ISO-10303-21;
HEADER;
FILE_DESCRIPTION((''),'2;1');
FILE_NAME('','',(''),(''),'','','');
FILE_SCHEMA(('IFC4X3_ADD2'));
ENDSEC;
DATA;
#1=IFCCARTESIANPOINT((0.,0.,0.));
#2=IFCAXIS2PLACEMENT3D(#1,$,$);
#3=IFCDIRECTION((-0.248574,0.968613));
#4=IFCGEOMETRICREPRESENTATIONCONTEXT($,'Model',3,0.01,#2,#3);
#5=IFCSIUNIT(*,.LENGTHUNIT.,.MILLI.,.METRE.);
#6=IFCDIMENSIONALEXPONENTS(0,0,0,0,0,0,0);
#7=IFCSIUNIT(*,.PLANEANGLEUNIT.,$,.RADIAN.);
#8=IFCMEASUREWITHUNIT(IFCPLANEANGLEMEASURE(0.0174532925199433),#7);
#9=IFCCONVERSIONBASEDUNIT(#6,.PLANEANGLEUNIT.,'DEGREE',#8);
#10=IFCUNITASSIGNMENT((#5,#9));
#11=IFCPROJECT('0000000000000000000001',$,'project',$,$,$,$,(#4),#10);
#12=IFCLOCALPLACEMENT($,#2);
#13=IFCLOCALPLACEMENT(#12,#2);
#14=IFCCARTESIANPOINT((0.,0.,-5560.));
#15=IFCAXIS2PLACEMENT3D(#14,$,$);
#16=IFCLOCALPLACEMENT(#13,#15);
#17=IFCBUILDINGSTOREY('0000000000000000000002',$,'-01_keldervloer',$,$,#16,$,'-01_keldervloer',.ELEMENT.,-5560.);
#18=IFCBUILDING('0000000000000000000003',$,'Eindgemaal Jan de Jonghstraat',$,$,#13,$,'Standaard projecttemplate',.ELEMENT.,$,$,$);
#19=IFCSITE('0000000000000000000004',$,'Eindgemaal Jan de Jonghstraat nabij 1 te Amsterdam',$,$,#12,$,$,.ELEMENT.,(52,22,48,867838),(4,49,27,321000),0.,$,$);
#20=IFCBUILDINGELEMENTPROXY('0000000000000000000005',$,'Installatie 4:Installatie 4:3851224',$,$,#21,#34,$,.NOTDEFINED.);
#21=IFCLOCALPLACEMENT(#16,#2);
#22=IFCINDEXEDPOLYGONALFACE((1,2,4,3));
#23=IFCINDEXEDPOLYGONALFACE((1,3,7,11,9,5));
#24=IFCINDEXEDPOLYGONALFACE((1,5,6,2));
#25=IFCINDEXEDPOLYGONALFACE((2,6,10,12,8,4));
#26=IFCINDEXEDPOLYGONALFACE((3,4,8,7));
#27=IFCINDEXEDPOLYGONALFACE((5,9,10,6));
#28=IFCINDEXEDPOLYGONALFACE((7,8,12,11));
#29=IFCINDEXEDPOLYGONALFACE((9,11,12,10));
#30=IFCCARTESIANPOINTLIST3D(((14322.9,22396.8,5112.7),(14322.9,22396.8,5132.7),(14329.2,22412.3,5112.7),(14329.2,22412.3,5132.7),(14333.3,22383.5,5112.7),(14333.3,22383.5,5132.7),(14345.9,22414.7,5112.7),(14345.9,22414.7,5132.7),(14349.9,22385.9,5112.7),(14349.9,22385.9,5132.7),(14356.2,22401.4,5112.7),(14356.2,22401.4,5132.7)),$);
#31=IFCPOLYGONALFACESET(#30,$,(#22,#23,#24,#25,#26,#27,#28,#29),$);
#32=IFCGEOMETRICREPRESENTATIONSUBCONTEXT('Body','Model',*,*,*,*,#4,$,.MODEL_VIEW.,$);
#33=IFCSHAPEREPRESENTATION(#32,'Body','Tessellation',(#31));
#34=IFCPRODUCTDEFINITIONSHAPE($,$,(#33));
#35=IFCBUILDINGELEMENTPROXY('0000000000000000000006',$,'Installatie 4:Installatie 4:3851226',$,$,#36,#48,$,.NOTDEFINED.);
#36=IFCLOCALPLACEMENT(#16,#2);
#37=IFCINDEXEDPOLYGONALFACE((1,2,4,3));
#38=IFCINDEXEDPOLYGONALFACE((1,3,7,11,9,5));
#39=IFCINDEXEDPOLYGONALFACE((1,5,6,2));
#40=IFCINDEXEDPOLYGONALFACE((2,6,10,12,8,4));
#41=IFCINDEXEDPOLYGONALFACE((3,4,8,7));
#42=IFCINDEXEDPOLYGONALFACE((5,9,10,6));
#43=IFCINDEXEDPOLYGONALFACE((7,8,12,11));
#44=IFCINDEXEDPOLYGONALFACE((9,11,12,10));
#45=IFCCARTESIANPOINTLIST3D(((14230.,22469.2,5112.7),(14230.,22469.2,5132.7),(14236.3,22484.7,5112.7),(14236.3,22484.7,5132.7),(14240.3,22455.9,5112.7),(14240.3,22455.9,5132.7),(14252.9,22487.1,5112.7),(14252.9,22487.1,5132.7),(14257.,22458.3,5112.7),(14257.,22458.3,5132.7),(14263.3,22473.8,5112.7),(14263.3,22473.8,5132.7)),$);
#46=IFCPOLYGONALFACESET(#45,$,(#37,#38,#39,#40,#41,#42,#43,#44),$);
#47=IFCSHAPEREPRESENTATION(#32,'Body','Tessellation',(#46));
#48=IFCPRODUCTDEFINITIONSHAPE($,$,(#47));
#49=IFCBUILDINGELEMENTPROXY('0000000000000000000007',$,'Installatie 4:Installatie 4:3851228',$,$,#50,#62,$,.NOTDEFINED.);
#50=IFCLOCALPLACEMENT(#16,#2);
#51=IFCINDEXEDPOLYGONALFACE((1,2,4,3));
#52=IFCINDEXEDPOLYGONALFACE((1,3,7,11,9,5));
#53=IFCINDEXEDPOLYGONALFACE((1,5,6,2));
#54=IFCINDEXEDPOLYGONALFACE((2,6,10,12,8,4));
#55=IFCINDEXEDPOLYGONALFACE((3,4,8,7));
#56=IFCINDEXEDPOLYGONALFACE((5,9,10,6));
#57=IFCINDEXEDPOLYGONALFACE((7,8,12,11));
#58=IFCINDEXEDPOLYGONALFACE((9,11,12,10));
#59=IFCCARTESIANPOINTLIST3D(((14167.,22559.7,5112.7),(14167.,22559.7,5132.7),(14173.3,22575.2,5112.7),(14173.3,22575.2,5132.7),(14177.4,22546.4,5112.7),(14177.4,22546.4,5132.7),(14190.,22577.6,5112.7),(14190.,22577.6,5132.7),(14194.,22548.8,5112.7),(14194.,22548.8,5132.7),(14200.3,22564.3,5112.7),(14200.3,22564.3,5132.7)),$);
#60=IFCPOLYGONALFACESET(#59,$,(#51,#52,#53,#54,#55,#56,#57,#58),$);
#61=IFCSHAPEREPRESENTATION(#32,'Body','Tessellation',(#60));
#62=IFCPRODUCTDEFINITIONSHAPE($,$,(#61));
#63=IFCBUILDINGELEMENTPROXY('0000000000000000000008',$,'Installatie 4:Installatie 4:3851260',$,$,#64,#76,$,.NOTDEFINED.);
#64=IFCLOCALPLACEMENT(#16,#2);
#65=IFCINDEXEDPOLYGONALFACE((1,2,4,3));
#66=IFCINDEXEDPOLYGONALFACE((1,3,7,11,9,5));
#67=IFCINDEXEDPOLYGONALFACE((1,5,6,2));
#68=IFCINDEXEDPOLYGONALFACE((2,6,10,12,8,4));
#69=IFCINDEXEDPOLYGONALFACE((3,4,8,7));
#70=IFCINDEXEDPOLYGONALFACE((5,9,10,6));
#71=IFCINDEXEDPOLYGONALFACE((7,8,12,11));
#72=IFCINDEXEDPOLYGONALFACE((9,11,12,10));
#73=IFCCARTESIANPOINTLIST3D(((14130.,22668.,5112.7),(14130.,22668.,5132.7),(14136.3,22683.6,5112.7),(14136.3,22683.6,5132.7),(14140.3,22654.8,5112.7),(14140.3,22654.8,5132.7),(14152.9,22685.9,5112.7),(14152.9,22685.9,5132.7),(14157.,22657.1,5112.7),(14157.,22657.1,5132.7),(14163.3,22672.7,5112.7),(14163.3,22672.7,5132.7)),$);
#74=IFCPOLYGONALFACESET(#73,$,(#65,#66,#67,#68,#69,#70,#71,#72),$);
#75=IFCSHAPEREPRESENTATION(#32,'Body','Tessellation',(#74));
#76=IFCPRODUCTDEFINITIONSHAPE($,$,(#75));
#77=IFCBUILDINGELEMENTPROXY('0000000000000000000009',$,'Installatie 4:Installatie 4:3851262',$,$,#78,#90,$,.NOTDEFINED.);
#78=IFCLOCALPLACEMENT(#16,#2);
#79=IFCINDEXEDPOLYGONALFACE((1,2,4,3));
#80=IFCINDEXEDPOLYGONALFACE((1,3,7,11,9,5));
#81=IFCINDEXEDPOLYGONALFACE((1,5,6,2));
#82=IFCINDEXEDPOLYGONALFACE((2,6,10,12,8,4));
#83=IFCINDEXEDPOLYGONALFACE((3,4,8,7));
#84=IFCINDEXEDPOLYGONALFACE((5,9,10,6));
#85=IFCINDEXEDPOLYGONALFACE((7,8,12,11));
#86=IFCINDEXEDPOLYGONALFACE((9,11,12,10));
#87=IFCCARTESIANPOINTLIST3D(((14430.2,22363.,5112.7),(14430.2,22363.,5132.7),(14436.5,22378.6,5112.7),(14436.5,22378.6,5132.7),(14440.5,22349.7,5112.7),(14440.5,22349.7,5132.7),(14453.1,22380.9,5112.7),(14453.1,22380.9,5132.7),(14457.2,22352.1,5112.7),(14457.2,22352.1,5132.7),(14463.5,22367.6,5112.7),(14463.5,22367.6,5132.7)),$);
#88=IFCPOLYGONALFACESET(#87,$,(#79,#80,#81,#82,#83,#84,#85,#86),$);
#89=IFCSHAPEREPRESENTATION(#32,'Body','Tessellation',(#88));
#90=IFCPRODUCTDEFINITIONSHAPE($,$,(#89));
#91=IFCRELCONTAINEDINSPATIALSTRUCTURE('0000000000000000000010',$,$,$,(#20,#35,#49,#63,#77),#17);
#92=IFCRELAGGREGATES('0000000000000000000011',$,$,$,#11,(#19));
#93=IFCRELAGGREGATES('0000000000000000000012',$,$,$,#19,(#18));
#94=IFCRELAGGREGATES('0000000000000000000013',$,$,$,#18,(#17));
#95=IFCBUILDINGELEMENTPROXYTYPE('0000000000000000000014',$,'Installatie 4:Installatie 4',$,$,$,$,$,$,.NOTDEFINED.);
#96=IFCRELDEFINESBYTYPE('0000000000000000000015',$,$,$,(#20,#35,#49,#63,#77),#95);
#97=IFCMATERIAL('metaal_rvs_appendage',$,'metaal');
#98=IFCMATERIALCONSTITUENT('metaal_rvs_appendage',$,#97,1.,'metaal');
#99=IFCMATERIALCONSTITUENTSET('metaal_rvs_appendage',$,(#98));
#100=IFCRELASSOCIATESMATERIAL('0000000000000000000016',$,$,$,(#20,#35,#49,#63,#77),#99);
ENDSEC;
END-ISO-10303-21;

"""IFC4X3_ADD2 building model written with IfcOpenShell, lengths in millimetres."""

from ifc_helpers import new_model, entity, si_unit, converted_unit, direction, frame, origin, place, context, subcontext, project, spatial, polyline, outline, extrude, source, transform, mapped, material, constituent, constituent_set, type_object, type_shapes, element, save


model = new_model("IFC4X3_ADD2")

# Units and contexts
model_context = context("Model", 3, precision=0.01, world=origin(), true_north=direction((-0.248574, 0.968613)))
body_context = subcontext(model_context, "Body", "Model", "MODEL_VIEW")
ifc_project = project(units=[si_unit("LENGTHUNIT", "METRE", prefix="MILLI"), converted_unit("PLANEANGLEUNIT", "DEGREE", entity("IfcPlaneAngleMeasure", 0.0174532925199433), si_unit("PLANEANGLEUNIT", "RADIAN"), dimensions=[0, 0, 0, 0, 0, 0, 0])], contexts=[model_context])

# Site, building, storey
site_placement = place(None, origin())
site = spatial("IfcSite", under=ifc_project, at=site_placement, Name="Eindgemaal Jan de Jonghstraat nabij 1 te Amsterdam", CompositionType="ELEMENT", RefLatitude=(52, 22, 48, 867838), RefLongitude=(4, 49, 27, 321000), RefElevation=0.0)
building_placement = place(site_placement, origin())
building = spatial("IfcBuilding", under=site, at=building_placement, Name="Eindgemaal Jan de Jonghstraat", LongName="Standaard projecttemplate", CompositionType="ELEMENT")
storey_placement = place(building_placement, frame((0.0, 0.0, -5560.0)))
storey = spatial("IfcBuildingStorey", under=building, at=storey_placement, Name="-01_keldervloer", LongName="-01_keldervloer", CompositionType="ELEMENT", Elevation=-5560.0)

# Building element proxies
ifc_material_1 = material(Name="metaal_rvs_appendage", Category="metaal")
ifc_constituent_1 = constituent(ifc_material_1, Name="metaal_rvs_appendage", Category="metaal", fraction=1.0)
ifc_constituent_set_1 = constituent_set(constituents=[ifc_constituent_1], Name="metaal_rvs_appendage")
building_element_proxy_type_1 = type_object("IfcBuildingElementProxyType", Name="Installatie 4:Installatie 4", PredefinedType="NOTDEFINED")
shared_shape_1 = source(origin(), body_context, "Body", "SweptSolid", [
    extrude(outline(polyline([(-8.4, -14.6), (8.4, -14.6), (16.8, 0.0), (8.4, 14.6), (-8.4, 14.6), (-16.8, 0.0), (-8.4, -14.6)])), frame((0.0, 0.0, -11.0), z_axis=(0.0, 0.0, 1.0), x_axis=(0.400458, -0.916315, 0.0)), (0.0, 0.0, 1.0), 20.0),
])
type_shapes(building_element_proxy_type_1, [shared_shape_1])
for number, where, z_axis, x_axis, name in (
    (1, (14339.6, 22399.1, 5123.7), (0.0, 0.0, 1.0), (0.968613, 0.248574, 0.0), "Installatie 4:Installatie 4:3851224"),
    (2, (14246.6, 22471.5, 5123.7), (0.0, 0.0, 1.0), (0.968613, 0.248574, 0.0), "Installatie 4:Installatie 4:3851226"),
    (3, (14183.7, 22562.0, 5123.7), (0.0, 0.0, 1.0), (0.968613, 0.248574, 0.0), "Installatie 4:Installatie 4:3851228"),
    (4, (14146.6, 22670.3, 5123.7), (0.0, 0.0, 1.0), (0.968613, 0.248574, 0.0), "Installatie 4:Installatie 4:3851260"),
    (5, (14446.8, 22365.3, 5123.7), (0.0, 0.0, 1.0), (0.968613, 0.248574, 0.0), "Installatie 4:Installatie 4:3851262"),
):
    element("IfcBuildingElementProxy", number, at=place(storey_placement, frame(where, z_axis=z_axis, x_axis=x_axis)), inside=storey, type_object=building_element_proxy_type_1, material=ifc_constituent_set_1, Name=name, PredefinedType="NOTDEFINED", context=body_context, shape_type="MappedRepresentation", body=[
        mapped(shared_shape_1, transform((0.0, 0.0, 0.0), scale=1.0)),
    ])

save(model, "model.ifc")
